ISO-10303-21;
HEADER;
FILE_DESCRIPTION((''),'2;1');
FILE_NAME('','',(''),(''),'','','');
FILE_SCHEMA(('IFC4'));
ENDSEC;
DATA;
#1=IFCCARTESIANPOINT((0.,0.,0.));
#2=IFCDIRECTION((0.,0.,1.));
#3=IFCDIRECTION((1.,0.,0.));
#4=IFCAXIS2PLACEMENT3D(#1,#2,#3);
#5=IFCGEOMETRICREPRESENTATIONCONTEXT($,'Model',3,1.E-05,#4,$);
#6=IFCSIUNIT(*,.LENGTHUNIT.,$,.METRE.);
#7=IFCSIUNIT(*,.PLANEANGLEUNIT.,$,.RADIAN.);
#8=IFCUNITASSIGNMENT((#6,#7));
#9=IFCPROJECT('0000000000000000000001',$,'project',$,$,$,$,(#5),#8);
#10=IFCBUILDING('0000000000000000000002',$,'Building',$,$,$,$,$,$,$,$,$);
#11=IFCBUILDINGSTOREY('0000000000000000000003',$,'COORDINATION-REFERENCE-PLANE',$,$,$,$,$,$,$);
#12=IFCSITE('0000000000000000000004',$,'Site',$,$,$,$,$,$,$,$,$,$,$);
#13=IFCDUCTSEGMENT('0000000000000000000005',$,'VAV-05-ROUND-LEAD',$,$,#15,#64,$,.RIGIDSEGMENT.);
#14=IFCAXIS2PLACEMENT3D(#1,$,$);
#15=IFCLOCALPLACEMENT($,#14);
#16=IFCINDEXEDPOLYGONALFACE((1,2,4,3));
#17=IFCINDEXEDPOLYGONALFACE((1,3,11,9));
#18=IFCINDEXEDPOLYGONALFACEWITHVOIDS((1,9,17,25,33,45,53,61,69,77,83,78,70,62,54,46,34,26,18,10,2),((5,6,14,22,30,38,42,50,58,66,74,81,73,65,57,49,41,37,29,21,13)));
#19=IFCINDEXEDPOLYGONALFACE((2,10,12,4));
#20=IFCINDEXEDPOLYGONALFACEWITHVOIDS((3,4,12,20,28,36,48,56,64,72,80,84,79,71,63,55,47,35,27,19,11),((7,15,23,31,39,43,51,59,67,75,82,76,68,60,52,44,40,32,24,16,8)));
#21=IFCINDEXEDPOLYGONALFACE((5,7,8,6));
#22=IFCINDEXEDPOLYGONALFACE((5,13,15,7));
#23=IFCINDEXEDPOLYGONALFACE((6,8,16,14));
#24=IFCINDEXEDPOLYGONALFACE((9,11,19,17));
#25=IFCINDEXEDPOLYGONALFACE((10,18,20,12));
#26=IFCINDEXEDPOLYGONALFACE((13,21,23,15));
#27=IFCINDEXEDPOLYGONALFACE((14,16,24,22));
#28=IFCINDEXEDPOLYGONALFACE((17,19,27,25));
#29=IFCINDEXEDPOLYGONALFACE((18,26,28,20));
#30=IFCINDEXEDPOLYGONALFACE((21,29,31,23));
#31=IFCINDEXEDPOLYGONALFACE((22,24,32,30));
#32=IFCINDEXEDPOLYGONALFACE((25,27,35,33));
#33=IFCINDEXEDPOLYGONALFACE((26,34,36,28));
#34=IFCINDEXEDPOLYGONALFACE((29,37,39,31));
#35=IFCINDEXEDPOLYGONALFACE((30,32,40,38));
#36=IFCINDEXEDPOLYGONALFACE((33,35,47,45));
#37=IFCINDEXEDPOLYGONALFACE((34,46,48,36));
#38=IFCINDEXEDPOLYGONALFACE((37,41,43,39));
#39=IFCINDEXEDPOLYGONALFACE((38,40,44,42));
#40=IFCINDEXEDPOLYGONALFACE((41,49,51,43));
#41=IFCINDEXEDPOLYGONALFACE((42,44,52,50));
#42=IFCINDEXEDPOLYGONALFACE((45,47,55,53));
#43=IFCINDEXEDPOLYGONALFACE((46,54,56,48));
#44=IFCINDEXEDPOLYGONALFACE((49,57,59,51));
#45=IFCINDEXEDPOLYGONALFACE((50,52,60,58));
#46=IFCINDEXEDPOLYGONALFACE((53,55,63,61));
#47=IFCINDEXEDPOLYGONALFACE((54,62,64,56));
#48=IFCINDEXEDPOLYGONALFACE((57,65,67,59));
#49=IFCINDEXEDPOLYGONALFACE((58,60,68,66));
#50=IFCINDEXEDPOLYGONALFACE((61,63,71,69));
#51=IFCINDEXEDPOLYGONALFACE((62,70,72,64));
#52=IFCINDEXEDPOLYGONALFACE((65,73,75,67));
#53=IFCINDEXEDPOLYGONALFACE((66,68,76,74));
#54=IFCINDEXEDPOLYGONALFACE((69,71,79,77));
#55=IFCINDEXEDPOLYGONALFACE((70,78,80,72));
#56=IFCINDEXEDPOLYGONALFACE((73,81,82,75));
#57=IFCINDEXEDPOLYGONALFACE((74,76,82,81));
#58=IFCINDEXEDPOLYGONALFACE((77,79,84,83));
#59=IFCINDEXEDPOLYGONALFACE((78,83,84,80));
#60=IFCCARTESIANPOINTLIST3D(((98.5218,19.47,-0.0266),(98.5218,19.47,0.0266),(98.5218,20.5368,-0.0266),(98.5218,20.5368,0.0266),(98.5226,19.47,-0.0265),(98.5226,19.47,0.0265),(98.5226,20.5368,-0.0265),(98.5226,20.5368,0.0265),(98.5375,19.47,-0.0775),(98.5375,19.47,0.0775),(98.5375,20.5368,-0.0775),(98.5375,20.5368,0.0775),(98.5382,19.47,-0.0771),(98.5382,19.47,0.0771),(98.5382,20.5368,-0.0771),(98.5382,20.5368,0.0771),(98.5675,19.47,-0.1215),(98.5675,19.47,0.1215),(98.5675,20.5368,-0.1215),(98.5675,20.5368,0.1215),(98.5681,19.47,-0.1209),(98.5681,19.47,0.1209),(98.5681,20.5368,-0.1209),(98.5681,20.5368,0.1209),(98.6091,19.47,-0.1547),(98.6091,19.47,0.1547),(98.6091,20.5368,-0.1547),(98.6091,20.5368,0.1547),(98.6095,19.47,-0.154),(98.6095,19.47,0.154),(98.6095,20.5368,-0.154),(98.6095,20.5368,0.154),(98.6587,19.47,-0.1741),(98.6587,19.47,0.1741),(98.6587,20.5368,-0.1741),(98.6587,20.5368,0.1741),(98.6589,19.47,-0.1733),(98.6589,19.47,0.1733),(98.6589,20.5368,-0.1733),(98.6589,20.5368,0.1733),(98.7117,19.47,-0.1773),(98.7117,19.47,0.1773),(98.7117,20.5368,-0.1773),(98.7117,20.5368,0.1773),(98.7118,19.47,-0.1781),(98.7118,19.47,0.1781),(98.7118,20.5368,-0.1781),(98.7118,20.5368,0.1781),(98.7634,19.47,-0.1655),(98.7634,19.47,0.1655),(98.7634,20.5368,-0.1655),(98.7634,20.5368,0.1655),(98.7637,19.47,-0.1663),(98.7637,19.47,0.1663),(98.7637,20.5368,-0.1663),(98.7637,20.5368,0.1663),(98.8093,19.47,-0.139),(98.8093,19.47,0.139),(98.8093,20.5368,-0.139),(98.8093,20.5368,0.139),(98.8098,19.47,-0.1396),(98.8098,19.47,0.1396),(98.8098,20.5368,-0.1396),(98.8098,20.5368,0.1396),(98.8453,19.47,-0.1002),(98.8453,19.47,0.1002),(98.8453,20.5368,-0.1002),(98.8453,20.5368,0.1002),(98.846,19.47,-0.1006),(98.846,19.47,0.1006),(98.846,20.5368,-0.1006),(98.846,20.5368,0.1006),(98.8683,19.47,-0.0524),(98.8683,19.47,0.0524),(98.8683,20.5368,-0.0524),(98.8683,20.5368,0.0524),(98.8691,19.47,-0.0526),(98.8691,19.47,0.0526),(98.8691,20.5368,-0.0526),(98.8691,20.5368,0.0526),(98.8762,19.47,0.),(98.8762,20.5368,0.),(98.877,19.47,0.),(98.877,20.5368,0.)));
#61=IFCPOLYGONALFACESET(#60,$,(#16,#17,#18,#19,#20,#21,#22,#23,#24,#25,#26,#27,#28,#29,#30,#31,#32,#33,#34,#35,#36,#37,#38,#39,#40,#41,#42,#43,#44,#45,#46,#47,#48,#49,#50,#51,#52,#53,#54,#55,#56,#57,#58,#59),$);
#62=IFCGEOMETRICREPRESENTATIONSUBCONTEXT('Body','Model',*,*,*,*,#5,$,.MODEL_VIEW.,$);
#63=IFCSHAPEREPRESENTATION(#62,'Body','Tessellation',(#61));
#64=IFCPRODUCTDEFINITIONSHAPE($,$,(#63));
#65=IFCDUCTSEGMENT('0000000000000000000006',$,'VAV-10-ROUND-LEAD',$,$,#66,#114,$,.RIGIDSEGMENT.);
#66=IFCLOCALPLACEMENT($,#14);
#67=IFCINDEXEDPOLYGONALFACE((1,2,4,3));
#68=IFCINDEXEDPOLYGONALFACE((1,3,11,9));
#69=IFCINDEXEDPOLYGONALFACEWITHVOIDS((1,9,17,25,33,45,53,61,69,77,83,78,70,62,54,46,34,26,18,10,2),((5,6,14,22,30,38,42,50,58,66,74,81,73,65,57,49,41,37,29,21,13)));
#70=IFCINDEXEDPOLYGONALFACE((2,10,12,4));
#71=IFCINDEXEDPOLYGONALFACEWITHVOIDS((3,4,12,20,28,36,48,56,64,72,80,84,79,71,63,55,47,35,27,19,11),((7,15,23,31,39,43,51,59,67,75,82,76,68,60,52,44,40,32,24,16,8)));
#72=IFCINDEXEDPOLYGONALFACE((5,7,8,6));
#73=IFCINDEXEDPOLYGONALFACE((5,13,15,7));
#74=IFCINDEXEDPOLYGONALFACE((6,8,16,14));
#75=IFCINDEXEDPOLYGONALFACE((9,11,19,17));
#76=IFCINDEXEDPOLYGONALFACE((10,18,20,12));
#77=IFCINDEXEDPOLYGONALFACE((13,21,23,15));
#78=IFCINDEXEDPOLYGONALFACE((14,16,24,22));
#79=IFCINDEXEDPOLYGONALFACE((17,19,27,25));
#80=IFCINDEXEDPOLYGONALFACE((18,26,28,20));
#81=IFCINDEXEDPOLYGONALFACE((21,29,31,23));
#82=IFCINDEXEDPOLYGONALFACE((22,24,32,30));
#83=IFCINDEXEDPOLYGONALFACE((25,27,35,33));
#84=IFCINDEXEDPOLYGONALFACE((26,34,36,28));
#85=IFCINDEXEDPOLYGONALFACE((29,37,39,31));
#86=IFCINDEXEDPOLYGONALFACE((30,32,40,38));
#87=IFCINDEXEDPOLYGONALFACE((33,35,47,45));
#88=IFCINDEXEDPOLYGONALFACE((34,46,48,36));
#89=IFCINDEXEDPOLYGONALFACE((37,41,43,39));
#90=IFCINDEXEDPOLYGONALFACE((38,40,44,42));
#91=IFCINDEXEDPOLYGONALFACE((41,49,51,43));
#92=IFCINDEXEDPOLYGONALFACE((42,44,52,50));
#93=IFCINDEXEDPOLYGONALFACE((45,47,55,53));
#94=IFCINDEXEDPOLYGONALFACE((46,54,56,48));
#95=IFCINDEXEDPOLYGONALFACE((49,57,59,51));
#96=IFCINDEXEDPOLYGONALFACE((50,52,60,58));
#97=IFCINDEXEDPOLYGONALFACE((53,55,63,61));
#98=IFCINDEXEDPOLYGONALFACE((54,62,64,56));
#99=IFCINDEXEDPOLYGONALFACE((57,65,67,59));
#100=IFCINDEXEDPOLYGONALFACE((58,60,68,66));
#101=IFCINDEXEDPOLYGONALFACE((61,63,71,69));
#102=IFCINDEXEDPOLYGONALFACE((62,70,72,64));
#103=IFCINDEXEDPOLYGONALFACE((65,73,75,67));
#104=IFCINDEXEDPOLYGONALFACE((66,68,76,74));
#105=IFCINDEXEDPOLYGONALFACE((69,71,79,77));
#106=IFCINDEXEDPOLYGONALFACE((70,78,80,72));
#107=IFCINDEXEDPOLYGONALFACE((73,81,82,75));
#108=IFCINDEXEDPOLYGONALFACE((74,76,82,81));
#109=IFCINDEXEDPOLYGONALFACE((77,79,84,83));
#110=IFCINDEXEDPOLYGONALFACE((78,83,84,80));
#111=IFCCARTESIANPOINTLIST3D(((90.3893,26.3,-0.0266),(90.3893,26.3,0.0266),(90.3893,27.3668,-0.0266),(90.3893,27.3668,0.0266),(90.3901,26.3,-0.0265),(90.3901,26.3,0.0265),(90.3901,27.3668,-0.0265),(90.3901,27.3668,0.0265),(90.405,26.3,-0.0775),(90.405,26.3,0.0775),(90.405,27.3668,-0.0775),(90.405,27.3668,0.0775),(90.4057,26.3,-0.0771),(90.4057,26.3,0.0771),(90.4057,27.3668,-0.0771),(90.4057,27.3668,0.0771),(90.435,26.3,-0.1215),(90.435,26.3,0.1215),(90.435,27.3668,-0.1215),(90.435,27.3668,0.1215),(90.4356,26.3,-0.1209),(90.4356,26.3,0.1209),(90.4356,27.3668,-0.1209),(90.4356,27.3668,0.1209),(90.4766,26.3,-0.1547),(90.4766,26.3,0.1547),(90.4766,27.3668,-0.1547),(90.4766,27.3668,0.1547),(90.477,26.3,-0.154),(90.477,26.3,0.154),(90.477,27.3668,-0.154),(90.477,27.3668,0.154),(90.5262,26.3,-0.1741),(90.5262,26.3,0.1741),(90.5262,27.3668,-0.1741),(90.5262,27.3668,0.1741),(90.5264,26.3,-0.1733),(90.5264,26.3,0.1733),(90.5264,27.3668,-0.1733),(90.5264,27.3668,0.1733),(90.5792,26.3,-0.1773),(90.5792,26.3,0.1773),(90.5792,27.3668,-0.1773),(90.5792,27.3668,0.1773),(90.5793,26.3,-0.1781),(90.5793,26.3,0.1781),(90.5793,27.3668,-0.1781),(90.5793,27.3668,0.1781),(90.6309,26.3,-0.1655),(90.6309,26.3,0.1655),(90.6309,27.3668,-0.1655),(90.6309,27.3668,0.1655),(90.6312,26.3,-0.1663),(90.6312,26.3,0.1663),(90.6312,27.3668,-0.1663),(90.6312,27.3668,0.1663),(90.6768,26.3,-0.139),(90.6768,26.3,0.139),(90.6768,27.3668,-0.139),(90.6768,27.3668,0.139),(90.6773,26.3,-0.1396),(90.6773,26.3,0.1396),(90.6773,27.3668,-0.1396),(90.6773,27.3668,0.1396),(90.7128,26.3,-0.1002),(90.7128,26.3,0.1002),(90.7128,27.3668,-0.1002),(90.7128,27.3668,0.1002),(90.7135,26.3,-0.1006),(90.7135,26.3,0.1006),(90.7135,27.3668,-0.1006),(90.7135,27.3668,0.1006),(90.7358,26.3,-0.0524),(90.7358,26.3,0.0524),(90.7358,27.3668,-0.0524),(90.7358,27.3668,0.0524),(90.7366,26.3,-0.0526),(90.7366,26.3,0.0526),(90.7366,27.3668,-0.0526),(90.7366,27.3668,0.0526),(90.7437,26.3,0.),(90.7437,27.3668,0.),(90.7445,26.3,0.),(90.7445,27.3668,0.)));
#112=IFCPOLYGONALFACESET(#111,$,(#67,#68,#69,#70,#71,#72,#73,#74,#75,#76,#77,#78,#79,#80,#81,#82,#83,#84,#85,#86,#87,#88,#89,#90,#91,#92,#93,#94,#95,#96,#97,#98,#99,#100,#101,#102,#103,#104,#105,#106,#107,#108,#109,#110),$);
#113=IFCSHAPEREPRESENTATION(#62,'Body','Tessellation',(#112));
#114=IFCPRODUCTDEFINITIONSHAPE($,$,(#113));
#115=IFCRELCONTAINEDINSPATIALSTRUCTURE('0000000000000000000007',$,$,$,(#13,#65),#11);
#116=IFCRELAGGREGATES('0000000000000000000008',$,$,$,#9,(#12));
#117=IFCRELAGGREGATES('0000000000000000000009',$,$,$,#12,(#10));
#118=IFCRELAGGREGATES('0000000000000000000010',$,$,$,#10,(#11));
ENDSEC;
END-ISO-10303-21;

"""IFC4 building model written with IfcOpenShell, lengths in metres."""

from ifc_helpers import new_model, si_unit, frame, origin, origin_with_axes, place, context, subcontext, project, spatial, hollow_circle, extrude, element, save


model = new_model("IFC4")

# Units and contexts
model_context = context("Model", 3, precision=1e-05, world=origin_with_axes())
body_context_1 = subcontext(model_context, "Body", "Model", "MODEL_VIEW")
ifc_project = project(units=[si_unit("LENGTHUNIT", "METRE"), si_unit("PLANEANGLEUNIT", "RADIAN")], contexts=[model_context])

# Site, building, storey
site = spatial("IfcSite", under=ifc_project, Name="Site")
building = spatial("IfcBuilding", under=site, Name="Building")
storey = spatial("IfcBuildingStorey", under=building, Name="COORDINATION-REFERENCE-PLANE")

# Duct segments
for number, where, z_axis, x_axis, name in (
    (1, (98.6984, 20.5368, 0.0), (0.0, -1.0, 0.0), (1.0, 0.0, 0.0), "VAV-05-ROUND-LEAD"),
    (2, (90.5659, 27.3668, 0.0), (0.0, -1.0, 0.0), (1.0, 0.0, 0.0), "VAV-10-ROUND-LEAD"),
):
    element("IfcDuctSegment", number, at=place(None, frame(where, z_axis=z_axis, x_axis=x_axis)), inside=storey, Name=name, PredefinedType="RIGIDSEGMENT", context=body_context_1, shape_type="SweptSolid", body=[
        extrude(hollow_circle(Radius=0.1786, WallThickness=0.0008), origin(), (0.0, 0.0, 1.0), 1.0668),
    ])

save(model, "model.ifc")
